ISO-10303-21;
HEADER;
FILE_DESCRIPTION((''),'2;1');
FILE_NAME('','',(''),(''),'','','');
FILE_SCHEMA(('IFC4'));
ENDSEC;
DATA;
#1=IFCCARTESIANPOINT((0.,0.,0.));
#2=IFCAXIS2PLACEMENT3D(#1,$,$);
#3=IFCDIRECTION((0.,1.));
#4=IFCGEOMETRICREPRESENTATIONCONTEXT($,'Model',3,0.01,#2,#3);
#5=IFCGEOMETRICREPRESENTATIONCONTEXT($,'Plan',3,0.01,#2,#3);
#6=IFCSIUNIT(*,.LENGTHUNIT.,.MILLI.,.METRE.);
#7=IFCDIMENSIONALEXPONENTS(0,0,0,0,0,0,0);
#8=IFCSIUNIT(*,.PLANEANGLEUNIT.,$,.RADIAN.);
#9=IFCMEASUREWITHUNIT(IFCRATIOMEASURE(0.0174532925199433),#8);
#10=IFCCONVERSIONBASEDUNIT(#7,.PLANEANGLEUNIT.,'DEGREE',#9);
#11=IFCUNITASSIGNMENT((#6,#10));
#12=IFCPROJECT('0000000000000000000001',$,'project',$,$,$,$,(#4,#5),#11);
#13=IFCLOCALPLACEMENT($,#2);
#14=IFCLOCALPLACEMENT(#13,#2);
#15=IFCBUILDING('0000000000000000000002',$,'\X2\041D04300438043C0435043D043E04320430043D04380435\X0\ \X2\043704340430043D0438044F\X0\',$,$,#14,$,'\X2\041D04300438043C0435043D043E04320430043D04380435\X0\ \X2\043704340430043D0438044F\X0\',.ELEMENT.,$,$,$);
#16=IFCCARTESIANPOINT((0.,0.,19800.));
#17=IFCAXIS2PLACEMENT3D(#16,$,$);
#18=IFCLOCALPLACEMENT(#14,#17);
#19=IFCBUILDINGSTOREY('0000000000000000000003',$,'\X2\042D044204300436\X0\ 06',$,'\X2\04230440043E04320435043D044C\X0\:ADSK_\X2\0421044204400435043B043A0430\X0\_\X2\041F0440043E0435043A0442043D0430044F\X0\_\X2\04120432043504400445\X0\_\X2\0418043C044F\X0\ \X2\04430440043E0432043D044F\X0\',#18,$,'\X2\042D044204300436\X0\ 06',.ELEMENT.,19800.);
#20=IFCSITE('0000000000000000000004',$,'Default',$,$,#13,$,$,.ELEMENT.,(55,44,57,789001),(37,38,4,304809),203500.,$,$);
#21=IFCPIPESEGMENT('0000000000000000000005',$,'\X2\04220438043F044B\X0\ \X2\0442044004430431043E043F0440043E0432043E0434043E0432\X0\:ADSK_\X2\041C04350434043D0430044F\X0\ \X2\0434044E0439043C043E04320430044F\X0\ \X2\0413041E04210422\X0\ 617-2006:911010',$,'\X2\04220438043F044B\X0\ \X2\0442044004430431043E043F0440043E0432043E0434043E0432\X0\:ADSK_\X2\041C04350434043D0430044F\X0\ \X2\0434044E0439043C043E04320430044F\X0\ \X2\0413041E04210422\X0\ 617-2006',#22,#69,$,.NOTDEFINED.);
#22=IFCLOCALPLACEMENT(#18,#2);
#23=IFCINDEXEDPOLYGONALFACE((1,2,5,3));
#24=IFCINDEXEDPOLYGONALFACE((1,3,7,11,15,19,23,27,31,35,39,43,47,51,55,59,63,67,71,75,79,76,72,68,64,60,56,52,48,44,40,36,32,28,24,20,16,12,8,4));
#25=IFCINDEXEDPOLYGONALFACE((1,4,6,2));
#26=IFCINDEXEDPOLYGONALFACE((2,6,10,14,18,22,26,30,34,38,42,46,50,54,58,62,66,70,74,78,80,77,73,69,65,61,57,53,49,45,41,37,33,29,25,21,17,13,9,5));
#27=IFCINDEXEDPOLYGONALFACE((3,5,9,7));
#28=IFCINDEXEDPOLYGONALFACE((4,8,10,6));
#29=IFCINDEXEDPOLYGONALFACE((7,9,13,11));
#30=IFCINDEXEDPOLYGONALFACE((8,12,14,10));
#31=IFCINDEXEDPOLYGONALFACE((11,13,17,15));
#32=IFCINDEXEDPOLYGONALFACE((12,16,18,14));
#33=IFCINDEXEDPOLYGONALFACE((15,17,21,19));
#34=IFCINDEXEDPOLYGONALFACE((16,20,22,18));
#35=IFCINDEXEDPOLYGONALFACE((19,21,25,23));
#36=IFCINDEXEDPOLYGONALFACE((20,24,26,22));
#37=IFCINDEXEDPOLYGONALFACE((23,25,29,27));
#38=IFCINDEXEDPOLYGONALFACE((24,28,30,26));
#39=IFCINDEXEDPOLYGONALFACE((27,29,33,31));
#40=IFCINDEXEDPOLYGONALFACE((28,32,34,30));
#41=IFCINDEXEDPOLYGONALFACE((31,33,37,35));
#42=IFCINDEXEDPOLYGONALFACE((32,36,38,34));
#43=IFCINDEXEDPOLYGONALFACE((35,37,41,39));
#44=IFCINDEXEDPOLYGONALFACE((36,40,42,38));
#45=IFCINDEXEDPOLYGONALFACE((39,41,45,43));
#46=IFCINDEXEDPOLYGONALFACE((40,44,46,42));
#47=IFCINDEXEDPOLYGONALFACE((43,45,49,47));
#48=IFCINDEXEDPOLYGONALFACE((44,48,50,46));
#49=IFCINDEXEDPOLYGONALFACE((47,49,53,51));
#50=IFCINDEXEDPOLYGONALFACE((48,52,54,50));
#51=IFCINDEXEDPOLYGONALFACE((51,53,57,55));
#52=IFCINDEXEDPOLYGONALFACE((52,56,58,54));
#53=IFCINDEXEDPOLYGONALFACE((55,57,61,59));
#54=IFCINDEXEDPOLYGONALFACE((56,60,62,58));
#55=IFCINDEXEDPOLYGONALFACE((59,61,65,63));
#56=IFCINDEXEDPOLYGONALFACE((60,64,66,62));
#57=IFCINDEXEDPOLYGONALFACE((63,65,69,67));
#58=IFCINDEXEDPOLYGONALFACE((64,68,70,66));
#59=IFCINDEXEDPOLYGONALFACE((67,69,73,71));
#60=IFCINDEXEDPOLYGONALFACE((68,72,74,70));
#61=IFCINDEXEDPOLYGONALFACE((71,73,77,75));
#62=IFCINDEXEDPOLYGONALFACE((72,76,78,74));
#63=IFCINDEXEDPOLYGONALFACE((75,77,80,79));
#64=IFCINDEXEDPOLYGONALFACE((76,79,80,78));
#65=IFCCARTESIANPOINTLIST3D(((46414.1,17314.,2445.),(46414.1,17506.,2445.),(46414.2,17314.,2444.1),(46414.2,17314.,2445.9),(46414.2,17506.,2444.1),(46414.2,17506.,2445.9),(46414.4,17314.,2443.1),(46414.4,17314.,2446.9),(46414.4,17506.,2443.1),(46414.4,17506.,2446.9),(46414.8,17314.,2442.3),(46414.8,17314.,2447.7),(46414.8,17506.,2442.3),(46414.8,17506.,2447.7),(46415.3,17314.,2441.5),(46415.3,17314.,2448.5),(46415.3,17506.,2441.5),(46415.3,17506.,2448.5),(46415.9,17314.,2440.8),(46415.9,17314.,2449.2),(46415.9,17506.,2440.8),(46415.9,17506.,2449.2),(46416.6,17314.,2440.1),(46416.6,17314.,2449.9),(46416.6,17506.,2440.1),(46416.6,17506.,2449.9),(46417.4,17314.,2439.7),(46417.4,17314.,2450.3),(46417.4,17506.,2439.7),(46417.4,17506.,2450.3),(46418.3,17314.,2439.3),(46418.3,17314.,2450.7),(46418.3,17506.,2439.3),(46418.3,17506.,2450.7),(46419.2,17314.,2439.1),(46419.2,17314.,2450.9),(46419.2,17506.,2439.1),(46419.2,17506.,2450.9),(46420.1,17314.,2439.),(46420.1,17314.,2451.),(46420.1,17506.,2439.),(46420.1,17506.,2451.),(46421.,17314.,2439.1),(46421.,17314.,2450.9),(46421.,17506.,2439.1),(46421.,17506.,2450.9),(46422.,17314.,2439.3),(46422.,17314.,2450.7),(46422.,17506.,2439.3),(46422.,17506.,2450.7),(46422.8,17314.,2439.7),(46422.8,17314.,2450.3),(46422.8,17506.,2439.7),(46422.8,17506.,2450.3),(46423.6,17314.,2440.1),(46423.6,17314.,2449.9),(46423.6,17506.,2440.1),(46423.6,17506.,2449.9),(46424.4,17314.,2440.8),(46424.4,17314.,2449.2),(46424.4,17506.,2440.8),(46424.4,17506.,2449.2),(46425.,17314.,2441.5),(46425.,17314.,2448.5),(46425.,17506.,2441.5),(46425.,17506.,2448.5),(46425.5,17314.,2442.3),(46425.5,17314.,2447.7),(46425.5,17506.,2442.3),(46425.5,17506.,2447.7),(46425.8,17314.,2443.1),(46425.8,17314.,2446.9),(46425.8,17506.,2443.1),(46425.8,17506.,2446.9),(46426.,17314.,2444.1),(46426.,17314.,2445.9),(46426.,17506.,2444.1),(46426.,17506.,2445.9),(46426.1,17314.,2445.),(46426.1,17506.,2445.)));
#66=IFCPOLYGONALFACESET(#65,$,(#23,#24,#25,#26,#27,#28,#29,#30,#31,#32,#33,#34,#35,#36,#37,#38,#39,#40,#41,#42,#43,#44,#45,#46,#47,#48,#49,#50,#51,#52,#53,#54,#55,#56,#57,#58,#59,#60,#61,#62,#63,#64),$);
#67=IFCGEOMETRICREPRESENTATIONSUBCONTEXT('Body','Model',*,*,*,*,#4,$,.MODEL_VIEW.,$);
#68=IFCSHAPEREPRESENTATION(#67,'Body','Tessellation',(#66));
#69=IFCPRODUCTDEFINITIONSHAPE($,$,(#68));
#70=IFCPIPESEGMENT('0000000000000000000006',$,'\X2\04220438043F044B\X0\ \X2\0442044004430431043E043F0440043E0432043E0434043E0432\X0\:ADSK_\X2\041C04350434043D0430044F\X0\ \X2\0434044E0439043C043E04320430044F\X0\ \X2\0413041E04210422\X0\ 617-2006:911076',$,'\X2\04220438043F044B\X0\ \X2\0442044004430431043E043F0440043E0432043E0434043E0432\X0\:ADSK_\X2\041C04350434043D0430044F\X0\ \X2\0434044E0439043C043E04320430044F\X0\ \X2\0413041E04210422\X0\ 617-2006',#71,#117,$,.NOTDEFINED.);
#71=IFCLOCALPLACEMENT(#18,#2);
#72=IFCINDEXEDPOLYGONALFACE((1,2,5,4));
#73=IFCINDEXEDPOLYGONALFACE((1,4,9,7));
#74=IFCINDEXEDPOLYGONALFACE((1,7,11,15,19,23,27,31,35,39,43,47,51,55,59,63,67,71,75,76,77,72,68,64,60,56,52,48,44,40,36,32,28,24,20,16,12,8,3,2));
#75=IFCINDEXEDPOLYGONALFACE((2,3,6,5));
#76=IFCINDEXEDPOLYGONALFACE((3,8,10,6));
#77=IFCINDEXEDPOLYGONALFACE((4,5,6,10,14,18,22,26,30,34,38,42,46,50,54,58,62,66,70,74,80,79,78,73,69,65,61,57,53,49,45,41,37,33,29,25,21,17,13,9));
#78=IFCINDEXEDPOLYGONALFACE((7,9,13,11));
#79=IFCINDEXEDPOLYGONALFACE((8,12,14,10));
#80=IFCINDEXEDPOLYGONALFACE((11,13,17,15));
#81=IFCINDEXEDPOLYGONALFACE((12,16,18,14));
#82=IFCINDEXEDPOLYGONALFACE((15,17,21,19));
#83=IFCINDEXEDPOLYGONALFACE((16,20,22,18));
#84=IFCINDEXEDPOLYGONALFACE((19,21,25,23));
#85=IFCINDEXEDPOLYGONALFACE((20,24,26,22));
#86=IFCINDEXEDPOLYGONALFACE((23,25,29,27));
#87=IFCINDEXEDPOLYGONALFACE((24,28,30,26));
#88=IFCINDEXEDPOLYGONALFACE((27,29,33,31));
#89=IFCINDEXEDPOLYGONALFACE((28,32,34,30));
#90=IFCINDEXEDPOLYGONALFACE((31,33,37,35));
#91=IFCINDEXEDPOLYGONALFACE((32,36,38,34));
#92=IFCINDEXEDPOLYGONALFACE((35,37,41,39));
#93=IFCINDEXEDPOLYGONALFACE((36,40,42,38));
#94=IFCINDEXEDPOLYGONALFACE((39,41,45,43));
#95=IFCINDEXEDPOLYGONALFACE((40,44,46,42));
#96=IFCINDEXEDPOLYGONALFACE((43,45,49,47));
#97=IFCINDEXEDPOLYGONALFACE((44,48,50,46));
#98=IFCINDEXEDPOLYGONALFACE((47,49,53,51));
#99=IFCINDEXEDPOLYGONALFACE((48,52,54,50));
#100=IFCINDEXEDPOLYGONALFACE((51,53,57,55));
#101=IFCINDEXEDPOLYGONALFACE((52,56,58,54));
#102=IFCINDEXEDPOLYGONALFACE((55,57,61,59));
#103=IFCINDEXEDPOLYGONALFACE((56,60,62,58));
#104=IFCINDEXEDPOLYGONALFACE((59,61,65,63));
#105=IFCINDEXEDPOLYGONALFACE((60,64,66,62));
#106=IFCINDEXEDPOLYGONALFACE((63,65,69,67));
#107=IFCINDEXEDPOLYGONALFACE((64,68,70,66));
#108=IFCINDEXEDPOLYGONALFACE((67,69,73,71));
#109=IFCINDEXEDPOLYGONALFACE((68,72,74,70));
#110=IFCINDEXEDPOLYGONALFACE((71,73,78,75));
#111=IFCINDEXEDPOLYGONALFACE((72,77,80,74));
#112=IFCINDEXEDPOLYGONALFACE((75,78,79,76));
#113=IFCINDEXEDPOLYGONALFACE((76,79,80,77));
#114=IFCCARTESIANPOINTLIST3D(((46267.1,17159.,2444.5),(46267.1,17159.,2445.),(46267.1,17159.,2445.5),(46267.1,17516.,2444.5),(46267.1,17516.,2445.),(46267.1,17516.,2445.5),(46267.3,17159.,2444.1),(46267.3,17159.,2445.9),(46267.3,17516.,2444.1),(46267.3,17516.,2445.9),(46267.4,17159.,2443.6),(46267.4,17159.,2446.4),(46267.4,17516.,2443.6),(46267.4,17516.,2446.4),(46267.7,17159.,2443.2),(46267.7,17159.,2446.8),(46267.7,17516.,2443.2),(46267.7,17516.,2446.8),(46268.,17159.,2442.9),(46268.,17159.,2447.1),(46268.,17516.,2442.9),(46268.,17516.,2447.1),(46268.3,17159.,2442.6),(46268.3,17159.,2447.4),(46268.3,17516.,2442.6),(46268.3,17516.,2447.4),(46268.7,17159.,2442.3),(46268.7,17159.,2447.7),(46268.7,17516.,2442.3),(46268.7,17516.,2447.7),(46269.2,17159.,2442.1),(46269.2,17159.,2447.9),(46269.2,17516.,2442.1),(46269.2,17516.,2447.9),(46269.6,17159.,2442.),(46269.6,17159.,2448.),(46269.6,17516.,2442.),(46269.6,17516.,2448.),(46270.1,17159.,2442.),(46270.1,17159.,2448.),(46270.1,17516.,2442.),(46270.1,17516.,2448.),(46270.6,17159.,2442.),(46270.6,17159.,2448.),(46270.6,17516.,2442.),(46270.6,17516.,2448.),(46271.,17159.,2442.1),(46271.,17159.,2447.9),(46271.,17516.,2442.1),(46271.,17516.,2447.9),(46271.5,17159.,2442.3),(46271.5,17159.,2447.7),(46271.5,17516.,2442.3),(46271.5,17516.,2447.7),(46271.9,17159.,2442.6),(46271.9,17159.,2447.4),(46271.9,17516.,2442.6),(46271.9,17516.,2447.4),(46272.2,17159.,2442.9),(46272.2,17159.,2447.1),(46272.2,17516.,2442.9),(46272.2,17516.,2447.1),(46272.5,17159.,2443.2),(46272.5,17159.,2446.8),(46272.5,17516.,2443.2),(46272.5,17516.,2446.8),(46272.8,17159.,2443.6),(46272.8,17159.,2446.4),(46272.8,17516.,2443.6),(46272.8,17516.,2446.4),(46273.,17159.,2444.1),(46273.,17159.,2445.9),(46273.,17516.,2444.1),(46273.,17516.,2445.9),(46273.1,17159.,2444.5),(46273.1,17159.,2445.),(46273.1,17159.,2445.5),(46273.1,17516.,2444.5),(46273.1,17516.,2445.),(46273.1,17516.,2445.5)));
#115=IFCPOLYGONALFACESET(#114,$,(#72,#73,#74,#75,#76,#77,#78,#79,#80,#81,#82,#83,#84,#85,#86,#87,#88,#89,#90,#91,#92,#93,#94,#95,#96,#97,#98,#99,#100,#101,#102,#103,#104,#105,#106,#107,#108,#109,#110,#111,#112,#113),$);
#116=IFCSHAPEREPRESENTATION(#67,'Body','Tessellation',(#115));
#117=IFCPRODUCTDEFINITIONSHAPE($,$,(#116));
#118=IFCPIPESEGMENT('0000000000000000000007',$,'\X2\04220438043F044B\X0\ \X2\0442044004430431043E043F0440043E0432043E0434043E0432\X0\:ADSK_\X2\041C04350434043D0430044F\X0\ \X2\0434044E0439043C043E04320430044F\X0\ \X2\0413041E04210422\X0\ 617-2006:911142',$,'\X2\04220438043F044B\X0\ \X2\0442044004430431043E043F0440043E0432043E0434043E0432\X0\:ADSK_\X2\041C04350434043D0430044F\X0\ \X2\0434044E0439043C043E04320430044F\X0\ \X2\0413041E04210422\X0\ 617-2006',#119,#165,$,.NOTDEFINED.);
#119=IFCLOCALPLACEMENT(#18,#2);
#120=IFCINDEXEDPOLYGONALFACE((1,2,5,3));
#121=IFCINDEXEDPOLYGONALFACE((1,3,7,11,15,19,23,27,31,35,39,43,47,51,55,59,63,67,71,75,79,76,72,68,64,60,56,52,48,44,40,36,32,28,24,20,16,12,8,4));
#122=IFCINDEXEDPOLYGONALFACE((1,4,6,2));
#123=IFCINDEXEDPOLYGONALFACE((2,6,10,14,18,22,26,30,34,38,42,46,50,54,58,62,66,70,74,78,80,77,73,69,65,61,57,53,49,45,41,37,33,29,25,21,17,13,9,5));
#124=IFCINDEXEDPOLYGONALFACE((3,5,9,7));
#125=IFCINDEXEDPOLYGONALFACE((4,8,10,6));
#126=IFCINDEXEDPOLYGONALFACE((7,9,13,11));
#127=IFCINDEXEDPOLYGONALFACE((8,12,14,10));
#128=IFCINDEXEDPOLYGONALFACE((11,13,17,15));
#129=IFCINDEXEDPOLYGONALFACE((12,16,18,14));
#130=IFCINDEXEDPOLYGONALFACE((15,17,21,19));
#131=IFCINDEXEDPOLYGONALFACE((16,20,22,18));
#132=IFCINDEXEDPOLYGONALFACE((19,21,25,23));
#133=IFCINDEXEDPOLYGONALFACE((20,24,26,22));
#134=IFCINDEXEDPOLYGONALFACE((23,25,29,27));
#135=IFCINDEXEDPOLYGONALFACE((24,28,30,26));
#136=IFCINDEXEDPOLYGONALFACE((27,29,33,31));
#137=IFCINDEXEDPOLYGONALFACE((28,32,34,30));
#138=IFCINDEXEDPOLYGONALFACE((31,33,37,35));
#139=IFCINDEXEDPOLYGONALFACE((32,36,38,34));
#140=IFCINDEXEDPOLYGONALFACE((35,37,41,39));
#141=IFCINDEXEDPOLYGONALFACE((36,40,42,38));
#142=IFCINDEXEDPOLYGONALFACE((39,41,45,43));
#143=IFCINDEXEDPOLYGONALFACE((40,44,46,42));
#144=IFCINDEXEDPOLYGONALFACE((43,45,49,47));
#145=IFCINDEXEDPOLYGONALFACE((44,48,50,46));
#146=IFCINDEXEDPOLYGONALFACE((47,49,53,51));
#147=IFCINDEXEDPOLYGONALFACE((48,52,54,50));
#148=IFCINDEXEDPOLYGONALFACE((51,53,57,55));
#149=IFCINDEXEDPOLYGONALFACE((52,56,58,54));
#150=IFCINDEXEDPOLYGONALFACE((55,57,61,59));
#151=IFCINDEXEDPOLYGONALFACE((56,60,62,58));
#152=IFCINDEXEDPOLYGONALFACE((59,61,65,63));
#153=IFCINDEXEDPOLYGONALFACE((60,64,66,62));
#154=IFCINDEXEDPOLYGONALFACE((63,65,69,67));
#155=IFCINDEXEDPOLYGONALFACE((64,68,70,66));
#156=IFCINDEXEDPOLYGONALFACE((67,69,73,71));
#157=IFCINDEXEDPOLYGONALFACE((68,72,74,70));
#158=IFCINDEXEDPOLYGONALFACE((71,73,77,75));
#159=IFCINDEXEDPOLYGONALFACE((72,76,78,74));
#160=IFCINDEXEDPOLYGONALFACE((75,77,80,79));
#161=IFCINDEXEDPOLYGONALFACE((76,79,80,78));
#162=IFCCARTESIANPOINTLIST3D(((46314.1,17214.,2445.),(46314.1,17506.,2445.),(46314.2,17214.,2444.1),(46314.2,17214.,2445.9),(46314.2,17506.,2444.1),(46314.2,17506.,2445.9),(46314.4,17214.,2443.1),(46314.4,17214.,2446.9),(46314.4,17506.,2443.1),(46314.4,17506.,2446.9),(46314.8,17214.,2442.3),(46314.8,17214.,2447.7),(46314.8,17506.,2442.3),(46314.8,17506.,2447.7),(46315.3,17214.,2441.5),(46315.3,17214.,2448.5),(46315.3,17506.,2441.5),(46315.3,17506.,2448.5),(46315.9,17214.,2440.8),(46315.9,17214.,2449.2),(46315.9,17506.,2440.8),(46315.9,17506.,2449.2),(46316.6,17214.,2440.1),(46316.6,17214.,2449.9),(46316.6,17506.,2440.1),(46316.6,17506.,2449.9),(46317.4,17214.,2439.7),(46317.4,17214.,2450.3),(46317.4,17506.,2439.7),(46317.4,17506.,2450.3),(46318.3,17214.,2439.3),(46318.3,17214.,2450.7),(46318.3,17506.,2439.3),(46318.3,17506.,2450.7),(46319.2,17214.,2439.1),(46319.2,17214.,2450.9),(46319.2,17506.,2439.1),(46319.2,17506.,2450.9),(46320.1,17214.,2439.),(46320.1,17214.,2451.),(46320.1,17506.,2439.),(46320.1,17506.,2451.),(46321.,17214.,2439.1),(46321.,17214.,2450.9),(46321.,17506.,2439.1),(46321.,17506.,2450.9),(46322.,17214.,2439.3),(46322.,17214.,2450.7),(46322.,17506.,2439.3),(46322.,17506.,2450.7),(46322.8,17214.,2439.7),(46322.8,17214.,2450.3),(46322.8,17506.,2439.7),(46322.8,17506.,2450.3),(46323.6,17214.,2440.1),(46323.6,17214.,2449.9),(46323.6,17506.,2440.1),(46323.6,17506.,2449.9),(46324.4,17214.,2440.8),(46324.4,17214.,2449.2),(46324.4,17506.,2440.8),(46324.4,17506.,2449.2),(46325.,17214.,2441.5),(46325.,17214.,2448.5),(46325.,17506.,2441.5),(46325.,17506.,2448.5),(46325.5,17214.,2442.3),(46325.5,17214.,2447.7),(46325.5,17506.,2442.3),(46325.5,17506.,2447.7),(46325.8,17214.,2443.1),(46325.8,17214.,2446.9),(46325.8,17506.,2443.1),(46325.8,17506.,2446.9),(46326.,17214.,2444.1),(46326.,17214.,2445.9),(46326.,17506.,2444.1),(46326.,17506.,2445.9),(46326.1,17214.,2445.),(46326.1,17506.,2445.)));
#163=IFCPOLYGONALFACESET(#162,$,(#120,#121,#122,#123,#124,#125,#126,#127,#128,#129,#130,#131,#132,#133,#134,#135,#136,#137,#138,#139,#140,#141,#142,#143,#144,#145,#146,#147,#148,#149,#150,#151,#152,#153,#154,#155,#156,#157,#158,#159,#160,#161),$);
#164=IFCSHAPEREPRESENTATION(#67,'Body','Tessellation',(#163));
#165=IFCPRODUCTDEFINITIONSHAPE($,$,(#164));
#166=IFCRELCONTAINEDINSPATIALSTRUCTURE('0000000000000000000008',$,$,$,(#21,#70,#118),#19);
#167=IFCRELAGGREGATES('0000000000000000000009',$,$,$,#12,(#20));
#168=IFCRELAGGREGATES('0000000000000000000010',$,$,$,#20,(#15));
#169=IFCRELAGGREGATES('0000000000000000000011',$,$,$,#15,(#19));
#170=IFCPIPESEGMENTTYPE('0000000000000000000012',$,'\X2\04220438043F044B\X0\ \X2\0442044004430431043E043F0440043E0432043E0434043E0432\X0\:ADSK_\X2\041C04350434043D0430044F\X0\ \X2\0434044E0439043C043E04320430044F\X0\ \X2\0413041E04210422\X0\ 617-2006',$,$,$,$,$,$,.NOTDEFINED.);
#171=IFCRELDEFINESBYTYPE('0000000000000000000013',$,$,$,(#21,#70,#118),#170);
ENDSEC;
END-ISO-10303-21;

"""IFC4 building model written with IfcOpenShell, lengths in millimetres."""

from ifc_helpers import new_model, entity, si_unit, converted_unit, direction, frame, origin, place, context, subcontext, project, spatial, indexed_curve, outline, extrude, type_object, element, save


model = new_model("IFC4")

# Units and contexts
model_context = context("Model", 3, precision=0.01, world=origin(), true_north=direction((0.0, 1.0)))
plan_context = context("Plan", 3, precision=0.01, world=origin(), true_north=direction((0.0, 1.0)))
body_context = subcontext(model_context, "Body", "Model", "MODEL_VIEW")
ifc_project = project(units=[si_unit("LENGTHUNIT", "METRE", prefix="MILLI"), converted_unit("PLANEANGLEUNIT", "DEGREE", entity("IfcRatioMeasure", 0.0174532925199433), si_unit("PLANEANGLEUNIT", "RADIAN"), dimensions=[0, 0, 0, 0, 0, 0, 0])], contexts=[model_context, plan_context])

# Site, building, storey
site_placement = place(None, origin())
site = spatial("IfcSite", under=ifc_project, at=site_placement, Name="Default", CompositionType="ELEMENT", RefLatitude=(55, 44, 57, 789001), RefLongitude=(37, 38, 4, 304809), RefElevation=203500.0)
building_placement = place(site_placement, origin())
building = spatial("IfcBuilding", under=site, at=building_placement, Name="Наименование здания", LongName="Наименование здания", CompositionType="ELEMENT")
storey_placement = place(building_placement, frame((0.0, 0.0, 19800.0)))
storey = spatial("IfcBuildingStorey", under=building, at=storey_placement, Name="Этаж 06", ObjectType="Уровень:ADSK_Стрелка_Проектная_Вверх_Имя уровня", LongName="Этаж 06", CompositionType="ELEMENT", Elevation=19800.0)

# Pipe segments
pipe_segment_type = type_object("IfcPipeSegmentType", Name="Типы трубопроводов:ADSK_Медная дюймовая ГОСТ 617-2006", PredefinedType="NOTDEFINED")
placement = place(storey_placement, origin())
element("IfcPipeSegment", 1, at=placement, inside=storey, type_object=pipe_segment_type, Name="Типы трубопроводов:ADSK_Медная дюймовая ГОСТ 617-2006:911010", ObjectType="Типы трубопроводов:ADSK_Медная дюймовая ГОСТ 617-2006", PredefinedType="NOTDEFINED", context=body_context, shape_type="SweptSolid", body=[
    extrude(outline(indexed_curve([(6.0, 0.0), (5.9, 0.9), (5.7, 1.9), (5.3, 2.7), (4.9, 3.5), (4.2, 4.2), (3.5, 4.9), (2.7, 5.3), (1.9, 5.7), (0.9, 5.9), (0.0, 6.0), (-0.9, 5.9), (-1.9, 5.7), (-2.7, 5.3), (-3.5, 4.9), (-4.2, 4.2), (-4.9, 3.5), (-5.3, 2.7), (-5.7, 1.9), (-5.9, 0.9), (-6.0, 0.0), (-5.9, -0.9), (-5.7, -1.9), (-5.3, -2.7), (-4.9, -3.5), (-4.2, -4.2), (-3.5, -4.9), (-2.7, -5.3), (-1.9, -5.7), (-0.9, -5.9), (0.0, -6.0), (0.9, -5.9), (1.9, -5.7), (2.7, -5.3), (3.5, -4.9), (4.2, -4.2), (4.9, -3.5), (5.3, -2.7), (5.7, -1.9), (5.9, -0.9), (6.0, 0.0)], self_intersect=False)), frame((46420.1, 17314.0, 2445.0), z_axis=(0.0, 1.0, 0.0), x_axis=(-1.0, 0.0, 0.0)), (0.0, 0.0, 1.0), 192.0),
])
element("IfcPipeSegment", 2, at=placement, inside=storey, type_object=pipe_segment_type, Name="Типы трубопроводов:ADSK_Медная дюймовая ГОСТ 617-2006:911076", ObjectType="Типы трубопроводов:ADSK_Медная дюймовая ГОСТ 617-2006", PredefinedType="NOTDEFINED", context=body_context, shape_type="SweptSolid", body=[
    extrude(outline(indexed_curve([(3.0, 0.0), (3.0, 0.5), (2.9, 0.9), (2.7, 1.4), (2.4, 1.8), (2.1, 2.1), (1.8, 2.4), (1.4, 2.7), (0.9, 2.9), (0.5, 3.0), (0.0, 3.0), (-0.5, 3.0), (-0.9, 2.9), (-1.4, 2.7), (-1.8, 2.4), (-2.1, 2.1), (-2.4, 1.8), (-2.7, 1.4), (-2.9, 0.9), (-3.0, 0.5), (-3.0, 0.0), (-3.0, -0.5), (-2.9, -0.9), (-2.7, -1.4), (-2.4, -1.8), (-2.1, -2.1), (-1.8, -2.4), (-1.4, -2.7), (-0.9, -2.9), (-0.5, -3.0), (0.0, -3.0), (0.5, -3.0), (0.9, -2.9), (1.4, -2.7), (1.8, -2.4), (2.1, -2.1), (2.4, -1.8), (2.7, -1.4), (2.9, -0.9), (3.0, -0.5), (3.0, 0.0)], self_intersect=False)), frame((46270.1, 17159.0, 2445.0), z_axis=(0.0, 1.0, 0.0), x_axis=(-1.0, 0.0, 0.0)), (0.0, 0.0, 1.0), 357.0),
])
element("IfcPipeSegment", 3, at=placement, inside=storey, type_object=pipe_segment_type, Name="Типы трубопроводов:ADSK_Медная дюймовая ГОСТ 617-2006:911142", ObjectType="Типы трубопроводов:ADSK_Медная дюймовая ГОСТ 617-2006", PredefinedType="NOTDEFINED", context=body_context, shape_type="SweptSolid", body=[
    extrude(outline(indexed_curve([(6.0, 0.0), (5.9, 0.9), (5.7, 1.9), (5.3, 2.7), (4.9, 3.5), (4.2, 4.2), (3.5, 4.9), (2.7, 5.3), (1.9, 5.7), (0.9, 5.9), (0.0, 6.0), (-0.9, 5.9), (-1.9, 5.7), (-2.7, 5.3), (-3.5, 4.9), (-4.2, 4.2), (-4.9, 3.5), (-5.3, 2.7), (-5.7, 1.9), (-5.9, 0.9), (-6.0, 0.0), (-5.9, -0.9), (-5.7, -1.9), (-5.3, -2.7), (-4.9, -3.5), (-4.2, -4.2), (-3.5, -4.9), (-2.7, -5.3), (-1.9, -5.7), (-0.9, -5.9), (0.0, -6.0), (0.9, -5.9), (1.9, -5.7), (2.7, -5.3), (3.5, -4.9), (4.2, -4.2), (4.9, -3.5), (5.3, -2.7), (5.7, -1.9), (5.9, -0.9), (6.0, 0.0)], self_intersect=False)), frame((46320.1, 17214.0, 2445.0), z_axis=(0.0, 1.0, 0.0), x_axis=(-1.0, 0.0, 0.0)), (0.0, 0.0, 1.0), 292.0),
])

save(model, "model.ifc")
